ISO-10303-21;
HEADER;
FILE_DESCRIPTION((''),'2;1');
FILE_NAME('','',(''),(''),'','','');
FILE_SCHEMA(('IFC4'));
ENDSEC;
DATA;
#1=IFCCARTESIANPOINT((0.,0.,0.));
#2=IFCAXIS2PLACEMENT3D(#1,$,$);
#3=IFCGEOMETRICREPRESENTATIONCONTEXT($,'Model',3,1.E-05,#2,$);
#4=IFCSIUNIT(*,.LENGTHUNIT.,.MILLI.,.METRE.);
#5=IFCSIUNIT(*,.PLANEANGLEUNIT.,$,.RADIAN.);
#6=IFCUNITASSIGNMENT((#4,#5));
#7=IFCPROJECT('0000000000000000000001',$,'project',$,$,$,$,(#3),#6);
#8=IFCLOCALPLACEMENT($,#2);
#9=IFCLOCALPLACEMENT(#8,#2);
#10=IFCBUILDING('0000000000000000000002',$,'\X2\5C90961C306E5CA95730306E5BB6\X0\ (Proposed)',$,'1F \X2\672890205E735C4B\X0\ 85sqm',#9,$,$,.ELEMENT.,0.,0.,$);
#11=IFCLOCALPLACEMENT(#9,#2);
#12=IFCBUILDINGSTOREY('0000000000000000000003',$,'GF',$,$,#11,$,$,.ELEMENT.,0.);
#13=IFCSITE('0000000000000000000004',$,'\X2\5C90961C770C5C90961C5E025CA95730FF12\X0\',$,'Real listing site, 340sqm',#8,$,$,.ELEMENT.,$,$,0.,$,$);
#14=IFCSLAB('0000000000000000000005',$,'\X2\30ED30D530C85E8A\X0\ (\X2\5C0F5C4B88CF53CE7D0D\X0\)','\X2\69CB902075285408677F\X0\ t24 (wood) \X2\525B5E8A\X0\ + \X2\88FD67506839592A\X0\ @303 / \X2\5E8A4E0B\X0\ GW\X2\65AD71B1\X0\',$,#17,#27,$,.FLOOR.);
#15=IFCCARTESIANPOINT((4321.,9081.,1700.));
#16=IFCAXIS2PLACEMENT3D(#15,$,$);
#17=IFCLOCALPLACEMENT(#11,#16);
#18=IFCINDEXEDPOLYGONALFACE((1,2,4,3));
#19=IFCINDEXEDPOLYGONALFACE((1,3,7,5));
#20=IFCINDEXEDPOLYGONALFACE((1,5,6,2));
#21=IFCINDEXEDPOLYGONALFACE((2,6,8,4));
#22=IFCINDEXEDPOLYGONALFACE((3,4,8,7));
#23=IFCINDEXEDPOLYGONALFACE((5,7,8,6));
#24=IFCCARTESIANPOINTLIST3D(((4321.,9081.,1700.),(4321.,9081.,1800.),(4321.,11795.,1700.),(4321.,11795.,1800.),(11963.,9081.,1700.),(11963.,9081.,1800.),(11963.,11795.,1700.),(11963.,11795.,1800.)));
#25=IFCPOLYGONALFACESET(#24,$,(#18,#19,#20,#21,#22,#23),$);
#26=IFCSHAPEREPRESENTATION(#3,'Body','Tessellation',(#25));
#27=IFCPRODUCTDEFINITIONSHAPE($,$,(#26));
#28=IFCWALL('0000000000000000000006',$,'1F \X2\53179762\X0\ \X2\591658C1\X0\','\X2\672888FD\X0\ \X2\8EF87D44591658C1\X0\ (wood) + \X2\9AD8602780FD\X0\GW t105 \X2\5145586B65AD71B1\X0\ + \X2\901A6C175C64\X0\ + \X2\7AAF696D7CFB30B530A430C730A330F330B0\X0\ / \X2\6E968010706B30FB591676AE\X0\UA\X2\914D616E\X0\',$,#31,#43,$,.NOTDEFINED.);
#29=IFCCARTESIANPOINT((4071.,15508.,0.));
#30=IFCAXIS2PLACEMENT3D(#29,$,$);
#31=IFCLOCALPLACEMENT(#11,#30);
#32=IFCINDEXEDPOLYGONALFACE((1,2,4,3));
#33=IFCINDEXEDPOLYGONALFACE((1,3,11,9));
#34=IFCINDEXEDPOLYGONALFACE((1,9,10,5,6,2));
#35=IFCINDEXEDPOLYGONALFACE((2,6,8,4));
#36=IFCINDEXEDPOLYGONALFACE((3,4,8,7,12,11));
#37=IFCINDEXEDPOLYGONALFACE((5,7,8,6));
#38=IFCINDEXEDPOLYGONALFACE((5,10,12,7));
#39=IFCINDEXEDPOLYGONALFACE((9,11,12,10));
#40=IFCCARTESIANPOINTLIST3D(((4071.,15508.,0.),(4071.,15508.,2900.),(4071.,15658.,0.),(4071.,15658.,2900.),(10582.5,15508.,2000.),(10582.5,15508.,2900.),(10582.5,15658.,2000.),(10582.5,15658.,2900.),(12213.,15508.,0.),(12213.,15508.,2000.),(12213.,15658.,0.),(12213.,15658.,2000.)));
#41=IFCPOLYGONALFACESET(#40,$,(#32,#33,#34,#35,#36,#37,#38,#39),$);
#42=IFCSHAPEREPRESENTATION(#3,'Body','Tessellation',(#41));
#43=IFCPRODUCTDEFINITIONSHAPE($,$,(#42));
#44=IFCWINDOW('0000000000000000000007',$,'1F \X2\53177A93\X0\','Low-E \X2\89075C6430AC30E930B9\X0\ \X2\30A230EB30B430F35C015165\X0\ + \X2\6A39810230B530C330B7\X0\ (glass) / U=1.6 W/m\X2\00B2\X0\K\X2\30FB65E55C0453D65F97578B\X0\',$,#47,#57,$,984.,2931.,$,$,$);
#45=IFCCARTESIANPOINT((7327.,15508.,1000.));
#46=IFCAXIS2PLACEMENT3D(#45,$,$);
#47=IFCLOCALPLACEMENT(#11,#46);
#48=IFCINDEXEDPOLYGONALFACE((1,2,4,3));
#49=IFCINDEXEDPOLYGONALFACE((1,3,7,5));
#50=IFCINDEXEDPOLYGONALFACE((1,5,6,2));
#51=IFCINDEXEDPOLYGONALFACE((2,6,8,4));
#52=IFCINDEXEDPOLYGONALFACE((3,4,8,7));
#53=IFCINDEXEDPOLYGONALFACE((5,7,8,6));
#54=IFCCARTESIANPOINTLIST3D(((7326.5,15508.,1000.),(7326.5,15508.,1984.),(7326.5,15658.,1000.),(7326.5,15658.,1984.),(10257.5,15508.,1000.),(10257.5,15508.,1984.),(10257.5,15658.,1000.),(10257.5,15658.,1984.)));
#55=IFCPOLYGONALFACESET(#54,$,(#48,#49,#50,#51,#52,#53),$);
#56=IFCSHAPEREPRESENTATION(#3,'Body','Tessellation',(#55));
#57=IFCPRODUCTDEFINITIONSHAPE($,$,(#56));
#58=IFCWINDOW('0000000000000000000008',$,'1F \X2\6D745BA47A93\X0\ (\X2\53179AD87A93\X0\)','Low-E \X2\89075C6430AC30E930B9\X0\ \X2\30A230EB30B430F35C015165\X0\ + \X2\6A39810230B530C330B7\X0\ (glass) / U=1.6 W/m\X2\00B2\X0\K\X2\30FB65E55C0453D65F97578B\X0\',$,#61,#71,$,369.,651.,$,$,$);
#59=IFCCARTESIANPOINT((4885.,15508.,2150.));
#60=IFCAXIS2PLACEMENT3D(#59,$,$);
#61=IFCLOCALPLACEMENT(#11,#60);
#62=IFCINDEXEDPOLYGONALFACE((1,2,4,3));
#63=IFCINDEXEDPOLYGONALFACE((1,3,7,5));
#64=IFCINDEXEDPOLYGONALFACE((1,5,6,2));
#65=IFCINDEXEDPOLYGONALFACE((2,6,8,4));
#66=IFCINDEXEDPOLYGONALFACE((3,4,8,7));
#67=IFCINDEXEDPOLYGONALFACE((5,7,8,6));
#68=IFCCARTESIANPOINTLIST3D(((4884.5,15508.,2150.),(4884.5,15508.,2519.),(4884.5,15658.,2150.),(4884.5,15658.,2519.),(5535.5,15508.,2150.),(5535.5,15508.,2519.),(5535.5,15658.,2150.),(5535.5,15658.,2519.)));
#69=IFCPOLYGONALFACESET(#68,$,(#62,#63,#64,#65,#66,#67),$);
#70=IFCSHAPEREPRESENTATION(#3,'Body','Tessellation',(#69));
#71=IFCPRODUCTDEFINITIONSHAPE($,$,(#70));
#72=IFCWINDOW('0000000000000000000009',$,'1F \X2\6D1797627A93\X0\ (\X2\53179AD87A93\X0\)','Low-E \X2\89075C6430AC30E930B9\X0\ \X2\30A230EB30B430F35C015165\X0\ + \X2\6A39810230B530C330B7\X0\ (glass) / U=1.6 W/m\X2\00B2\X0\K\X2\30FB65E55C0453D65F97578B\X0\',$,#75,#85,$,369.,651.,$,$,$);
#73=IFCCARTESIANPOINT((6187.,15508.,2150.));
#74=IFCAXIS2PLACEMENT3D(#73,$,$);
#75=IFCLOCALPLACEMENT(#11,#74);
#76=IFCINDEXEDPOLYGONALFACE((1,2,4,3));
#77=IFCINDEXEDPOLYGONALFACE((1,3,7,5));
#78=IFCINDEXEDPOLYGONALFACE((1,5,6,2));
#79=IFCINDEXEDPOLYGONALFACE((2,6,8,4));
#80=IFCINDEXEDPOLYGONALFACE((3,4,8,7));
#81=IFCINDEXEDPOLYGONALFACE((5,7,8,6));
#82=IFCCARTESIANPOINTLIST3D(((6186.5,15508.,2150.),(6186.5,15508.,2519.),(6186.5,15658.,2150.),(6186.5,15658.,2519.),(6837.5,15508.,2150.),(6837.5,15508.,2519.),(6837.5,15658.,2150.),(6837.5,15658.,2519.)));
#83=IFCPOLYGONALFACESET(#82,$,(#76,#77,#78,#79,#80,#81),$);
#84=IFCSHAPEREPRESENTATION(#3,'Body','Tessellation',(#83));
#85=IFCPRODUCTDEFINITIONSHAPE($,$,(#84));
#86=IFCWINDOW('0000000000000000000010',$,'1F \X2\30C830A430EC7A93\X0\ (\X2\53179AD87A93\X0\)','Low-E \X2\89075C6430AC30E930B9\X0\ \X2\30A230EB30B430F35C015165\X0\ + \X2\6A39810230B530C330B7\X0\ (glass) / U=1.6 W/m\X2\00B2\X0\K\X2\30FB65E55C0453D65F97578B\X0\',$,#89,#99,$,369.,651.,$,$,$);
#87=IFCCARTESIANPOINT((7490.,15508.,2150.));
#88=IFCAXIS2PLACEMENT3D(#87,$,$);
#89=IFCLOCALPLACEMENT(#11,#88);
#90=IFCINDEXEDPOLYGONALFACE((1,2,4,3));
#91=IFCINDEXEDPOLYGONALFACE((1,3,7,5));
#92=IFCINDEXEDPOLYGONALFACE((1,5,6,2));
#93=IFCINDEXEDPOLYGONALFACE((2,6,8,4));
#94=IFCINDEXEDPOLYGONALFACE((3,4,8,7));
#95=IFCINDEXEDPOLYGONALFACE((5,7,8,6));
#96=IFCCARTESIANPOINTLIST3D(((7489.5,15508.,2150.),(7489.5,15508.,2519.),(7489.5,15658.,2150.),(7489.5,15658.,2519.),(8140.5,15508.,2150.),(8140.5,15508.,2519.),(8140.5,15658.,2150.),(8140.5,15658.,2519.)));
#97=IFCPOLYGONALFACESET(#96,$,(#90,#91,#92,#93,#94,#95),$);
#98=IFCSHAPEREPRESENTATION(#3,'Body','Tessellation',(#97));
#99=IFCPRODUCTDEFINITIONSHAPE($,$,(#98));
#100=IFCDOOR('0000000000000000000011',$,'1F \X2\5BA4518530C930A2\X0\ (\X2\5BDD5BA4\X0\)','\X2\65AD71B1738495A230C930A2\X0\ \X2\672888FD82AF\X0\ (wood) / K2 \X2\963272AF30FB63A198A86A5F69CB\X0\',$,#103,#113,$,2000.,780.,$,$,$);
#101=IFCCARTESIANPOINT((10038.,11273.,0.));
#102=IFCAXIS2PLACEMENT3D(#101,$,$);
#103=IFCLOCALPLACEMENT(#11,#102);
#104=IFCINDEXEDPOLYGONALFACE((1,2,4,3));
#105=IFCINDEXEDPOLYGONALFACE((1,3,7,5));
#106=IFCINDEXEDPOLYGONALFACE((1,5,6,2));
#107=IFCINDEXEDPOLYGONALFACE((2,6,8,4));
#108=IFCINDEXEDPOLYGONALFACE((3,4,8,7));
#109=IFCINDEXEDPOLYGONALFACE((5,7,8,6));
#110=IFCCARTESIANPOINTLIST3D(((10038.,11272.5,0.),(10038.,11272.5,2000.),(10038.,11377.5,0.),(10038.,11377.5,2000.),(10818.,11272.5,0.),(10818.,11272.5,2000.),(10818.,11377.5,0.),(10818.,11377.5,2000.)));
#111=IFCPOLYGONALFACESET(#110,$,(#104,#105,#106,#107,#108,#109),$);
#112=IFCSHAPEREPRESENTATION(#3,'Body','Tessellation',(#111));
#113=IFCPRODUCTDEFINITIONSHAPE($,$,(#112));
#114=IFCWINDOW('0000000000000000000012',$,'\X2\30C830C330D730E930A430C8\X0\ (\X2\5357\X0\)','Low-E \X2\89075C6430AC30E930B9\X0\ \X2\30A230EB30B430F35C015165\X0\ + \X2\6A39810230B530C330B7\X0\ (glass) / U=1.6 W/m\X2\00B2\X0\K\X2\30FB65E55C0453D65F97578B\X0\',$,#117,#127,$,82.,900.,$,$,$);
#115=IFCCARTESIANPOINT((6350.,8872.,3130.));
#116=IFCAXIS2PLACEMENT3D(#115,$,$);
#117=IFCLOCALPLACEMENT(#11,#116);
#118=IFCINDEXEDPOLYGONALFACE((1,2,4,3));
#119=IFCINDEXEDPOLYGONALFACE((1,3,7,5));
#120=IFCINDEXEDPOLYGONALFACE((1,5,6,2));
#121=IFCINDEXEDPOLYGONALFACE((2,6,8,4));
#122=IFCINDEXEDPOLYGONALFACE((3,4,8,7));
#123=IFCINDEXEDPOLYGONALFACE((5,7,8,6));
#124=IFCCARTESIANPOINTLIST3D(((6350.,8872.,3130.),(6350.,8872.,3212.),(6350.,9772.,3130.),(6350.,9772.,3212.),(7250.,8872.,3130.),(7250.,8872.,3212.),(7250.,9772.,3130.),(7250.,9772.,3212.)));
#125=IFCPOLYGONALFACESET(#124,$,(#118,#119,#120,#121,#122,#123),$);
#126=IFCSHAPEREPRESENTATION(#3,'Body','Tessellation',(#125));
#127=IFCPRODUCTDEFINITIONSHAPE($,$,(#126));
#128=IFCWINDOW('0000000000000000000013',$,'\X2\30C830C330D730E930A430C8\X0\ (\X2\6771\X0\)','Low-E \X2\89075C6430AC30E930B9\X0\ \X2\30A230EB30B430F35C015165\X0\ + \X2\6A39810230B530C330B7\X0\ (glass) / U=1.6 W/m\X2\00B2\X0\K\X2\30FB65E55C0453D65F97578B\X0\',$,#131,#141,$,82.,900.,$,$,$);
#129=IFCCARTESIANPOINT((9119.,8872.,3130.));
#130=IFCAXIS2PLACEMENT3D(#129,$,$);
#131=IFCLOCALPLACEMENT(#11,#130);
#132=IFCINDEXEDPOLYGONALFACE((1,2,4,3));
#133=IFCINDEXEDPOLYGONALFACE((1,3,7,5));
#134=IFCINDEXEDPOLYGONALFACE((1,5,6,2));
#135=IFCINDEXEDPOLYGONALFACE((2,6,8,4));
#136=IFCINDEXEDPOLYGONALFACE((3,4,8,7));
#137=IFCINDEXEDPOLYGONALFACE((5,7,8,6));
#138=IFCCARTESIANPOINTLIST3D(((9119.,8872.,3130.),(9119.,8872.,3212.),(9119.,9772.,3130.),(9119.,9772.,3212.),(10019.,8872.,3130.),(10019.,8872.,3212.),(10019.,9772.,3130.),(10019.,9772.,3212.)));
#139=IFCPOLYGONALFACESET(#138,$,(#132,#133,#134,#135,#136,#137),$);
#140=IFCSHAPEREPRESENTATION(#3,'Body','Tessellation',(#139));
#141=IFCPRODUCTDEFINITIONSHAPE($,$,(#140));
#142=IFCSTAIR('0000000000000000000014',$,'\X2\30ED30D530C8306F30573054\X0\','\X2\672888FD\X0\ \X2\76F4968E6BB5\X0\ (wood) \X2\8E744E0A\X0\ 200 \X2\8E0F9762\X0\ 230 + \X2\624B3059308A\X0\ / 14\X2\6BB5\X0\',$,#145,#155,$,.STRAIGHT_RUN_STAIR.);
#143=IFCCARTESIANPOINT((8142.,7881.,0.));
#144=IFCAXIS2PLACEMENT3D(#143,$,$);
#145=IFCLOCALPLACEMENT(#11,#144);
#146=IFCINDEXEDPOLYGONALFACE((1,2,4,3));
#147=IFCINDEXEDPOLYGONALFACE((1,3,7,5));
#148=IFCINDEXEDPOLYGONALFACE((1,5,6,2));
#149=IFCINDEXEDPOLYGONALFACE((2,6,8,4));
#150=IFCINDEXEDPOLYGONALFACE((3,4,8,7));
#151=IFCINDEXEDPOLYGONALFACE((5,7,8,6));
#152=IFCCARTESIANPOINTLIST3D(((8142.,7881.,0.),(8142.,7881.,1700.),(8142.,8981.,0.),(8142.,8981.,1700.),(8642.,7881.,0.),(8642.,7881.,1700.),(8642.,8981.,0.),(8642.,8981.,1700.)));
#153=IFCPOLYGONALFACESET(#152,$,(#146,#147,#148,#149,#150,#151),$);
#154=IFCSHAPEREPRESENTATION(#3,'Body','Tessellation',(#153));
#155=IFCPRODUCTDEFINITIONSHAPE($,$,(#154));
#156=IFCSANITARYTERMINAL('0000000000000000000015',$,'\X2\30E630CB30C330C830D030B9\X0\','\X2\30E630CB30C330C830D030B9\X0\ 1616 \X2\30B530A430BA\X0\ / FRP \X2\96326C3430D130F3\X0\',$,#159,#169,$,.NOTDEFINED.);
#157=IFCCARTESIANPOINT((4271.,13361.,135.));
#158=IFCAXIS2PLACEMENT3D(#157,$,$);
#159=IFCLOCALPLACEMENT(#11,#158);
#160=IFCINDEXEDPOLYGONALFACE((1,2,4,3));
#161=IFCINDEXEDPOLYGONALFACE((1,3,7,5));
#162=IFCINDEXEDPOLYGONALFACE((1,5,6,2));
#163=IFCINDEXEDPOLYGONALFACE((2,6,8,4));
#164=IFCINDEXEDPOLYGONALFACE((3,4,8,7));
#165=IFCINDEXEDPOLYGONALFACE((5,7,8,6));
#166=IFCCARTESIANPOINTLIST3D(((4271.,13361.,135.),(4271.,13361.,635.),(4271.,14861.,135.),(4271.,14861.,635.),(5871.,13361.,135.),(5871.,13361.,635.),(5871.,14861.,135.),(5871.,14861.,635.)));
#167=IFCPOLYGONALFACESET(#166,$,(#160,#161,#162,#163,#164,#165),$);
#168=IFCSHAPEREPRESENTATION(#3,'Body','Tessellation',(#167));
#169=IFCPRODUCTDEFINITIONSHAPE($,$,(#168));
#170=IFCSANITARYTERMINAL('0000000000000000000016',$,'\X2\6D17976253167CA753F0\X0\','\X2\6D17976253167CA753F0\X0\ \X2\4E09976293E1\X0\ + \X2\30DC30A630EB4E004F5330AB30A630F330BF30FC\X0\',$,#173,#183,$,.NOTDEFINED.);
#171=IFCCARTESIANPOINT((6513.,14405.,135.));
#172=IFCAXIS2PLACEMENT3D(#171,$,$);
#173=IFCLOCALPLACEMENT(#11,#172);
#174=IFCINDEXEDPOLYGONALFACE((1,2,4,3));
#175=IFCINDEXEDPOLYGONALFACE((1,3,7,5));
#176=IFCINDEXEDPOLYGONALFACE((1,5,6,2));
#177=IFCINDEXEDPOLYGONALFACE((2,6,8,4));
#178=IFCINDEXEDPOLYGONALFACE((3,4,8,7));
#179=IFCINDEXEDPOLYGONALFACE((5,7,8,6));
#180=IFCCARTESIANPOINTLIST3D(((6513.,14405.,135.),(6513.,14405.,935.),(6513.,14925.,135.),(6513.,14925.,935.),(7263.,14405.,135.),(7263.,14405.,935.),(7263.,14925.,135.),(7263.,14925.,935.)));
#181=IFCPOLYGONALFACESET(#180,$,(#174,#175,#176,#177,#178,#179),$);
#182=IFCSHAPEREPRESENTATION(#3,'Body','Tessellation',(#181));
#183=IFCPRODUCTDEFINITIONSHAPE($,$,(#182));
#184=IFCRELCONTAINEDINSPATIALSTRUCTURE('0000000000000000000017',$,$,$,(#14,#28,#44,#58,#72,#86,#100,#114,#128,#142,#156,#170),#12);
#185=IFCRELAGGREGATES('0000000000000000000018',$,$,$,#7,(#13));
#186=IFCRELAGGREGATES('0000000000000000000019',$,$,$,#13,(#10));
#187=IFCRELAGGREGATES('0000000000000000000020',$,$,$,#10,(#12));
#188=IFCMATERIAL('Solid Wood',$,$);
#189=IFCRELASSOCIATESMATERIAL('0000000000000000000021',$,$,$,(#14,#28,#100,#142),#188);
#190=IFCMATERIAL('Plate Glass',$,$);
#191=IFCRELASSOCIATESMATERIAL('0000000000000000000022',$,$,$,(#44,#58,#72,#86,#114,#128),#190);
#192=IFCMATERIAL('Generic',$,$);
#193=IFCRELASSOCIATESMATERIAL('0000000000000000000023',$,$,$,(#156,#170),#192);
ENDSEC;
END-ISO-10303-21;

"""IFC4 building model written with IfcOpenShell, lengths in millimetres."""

from ifc_helpers import new_model, si_unit, frame, frame_2d, origin, place, context, project, spatial, rectangle, extrude, material, element, fill, save


model = new_model("IFC4")

# Units and contexts
model_context = context("Model", 3, precision=1e-05, world=origin())
ifc_project = project(units=[si_unit("LENGTHUNIT", "METRE", prefix="MILLI"), si_unit("PLANEANGLEUNIT", "RADIAN")], contexts=[model_context])

# Site, building, storey
site_placement = place(None, origin())
site = spatial("IfcSite", under=ifc_project, at=site_placement, Name="岐阜県岐阜市岩地２", ObjectType="Real listing site, 340sqm", CompositionType="ELEMENT", RefElevation=0.0)
building_placement = place(site_placement, origin())
building = spatial("IfcBuilding", under=site, at=building_placement, Name="岐阜の岩地の家 (Proposed)", ObjectType="1F 木造平屋 85sqm", CompositionType="ELEMENT", ElevationOfRefHeight=0.0, ElevationOfTerrain=0.0)
storey_placement = place(building_placement, origin())
storey = spatial("IfcBuildingStorey", under=building, at=storey_placement, Name="GF", CompositionType="ELEMENT", Elevation=0.0)

# Slab
ifc_material_1 = material(Name="Solid Wood")
slab_placement = place(storey_placement, frame((4321.0, 9081.0, 1700.0)))
element("IfcSlab", 1, at=slab_placement, inside=storey, material=ifc_material_1, Name="ロフト床 (小屋裏収納)", Description="構造用合板 t24 (wood) 剛床 + 製材根太 @303 / 床下 GW断熱", PredefinedType="FLOOR", context=model_context, shape_type="SweptSolid", body=[
    extrude(rectangle(XDim=7642.0, YDim=2714.0, at=frame_2d((3821.0, 1357.0))), frame((4321.0, 9081.0, 1700.0)), (0.0, 0.0, 1.0), 100.0),
])

# Wall, openings, windows
wall_1_placement = place(storey_placement, frame((4071.0, 15508.0, 0.0)))
wall_1 = element("IfcWall", 2, at=wall_1_placement, inside=storey, material=ifc_material_1, Name="1F 北面 外壁", Description="木製 軸組外壁 (wood) + 高性能GW t105 充填断熱 + 通気層 + 窯業系サイディング / 準耐火・外皮UA配慮", PredefinedType="NOTDEFINED", context=model_context, shape_type="SweptSolid", body=[
    extrude(rectangle(XDim=8142.0, YDim=150.0, at=frame_2d((4071.0, 75.0))), frame((4071.0, 15508.0, 0.0)), (0.0, 0.0, 1.0), 2900.0),
])
opening_1_placement = place(storey_placement, frame((7327.0, 15508.0, 1000.0)))
opening_1 = element("IfcOpeningElement", 3, at=opening_1_placement, cuts=wall_1, PredefinedType="NOTDEFINED", context=model_context, shape_type="SweptSolid", body=[
    extrude(rectangle(XDim=2931.0, YDim=150.0, at=frame_2d((1465.0, 75.0))), frame((7327.0, 15508.0, 1000.0)), (0.0, 0.0, 1.0), 984.0),
])
opening_2_placement = place(storey_placement, frame((4885.0, 15508.0, 2150.0)))
opening_2 = element("IfcOpeningElement", 4, at=opening_2_placement, cuts=wall_1, PredefinedType="NOTDEFINED", context=model_context, shape_type="SweptSolid", body=[
    extrude(rectangle(XDim=651.0, YDim=150.0, at=frame_2d((325.0, 75.0))), frame((4885.0, 15508.0, 2150.0)), (0.0, 0.0, 1.0), 369.0),
])
opening_3_placement = place(storey_placement, frame((6187.0, 15508.0, 2150.0)))
opening_3 = element("IfcOpeningElement", 5, at=opening_3_placement, cuts=wall_1, PredefinedType="NOTDEFINED", context=model_context, shape_type="SweptSolid", body=[
    extrude(rectangle(XDim=651.0, YDim=150.0, at=frame_2d((325.0, 75.0))), frame((6187.0, 15508.0, 2150.0)), (0.0, 0.0, 1.0), 369.0),
])
opening_4_placement = place(storey_placement, frame((7490.0, 15508.0, 2150.0)))
opening_4 = element("IfcOpeningElement", 6, at=opening_4_placement, cuts=wall_1, PredefinedType="NOTDEFINED", context=model_context, shape_type="SweptSolid", body=[
    extrude(rectangle(XDim=651.0, YDim=150.0, at=frame_2d((325.0, 75.0))), frame((7490.0, 15508.0, 2150.0)), (0.0, 0.0, 1.0), 369.0),
])
ifc_material_2 = material(Name="Plate Glass")
window_1_placement = place(storey_placement, frame((7327.0, 15508.0, 1000.0)))
window_1 = element("IfcWindow", 7, at=window_1_placement, inside=storey, material=ifc_material_2, Name="1F 北窓", Description="Low-E 複層ガラス アルゴン封入 + 樹脂サッシ (glass) / U=1.6 W/m²K・日射取得型", OverallHeight=984.0, OverallWidth=2931.0, context=model_context, shape_type="SweptSolid", body=[
    extrude(rectangle(XDim=2931.0, YDim=150.0, at=frame_2d((1465.0, 75.0))), frame((7327.0, 15508.0, 1000.0)), (0.0, 0.0, 1.0), 984.0),
])
fill(opening_1, window_1)
window_2_placement = place(storey_placement, frame((4885.0, 15508.0, 2150.0)))
window_2 = element("IfcWindow", 8, at=window_2_placement, inside=storey, material=ifc_material_2, Name="1F 浴室窓 (北高窓)", Description="Low-E 複層ガラス アルゴン封入 + 樹脂サッシ (glass) / U=1.6 W/m²K・日射取得型", OverallHeight=369.0, OverallWidth=651.0, context=model_context, shape_type="SweptSolid", body=[
    extrude(rectangle(XDim=651.0, YDim=150.0, at=frame_2d((325.0, 75.0))), frame((4885.0, 15508.0, 2150.0)), (0.0, 0.0, 1.0), 369.0),
])
fill(opening_2, window_2)
window_3_placement = place(storey_placement, frame((6187.0, 15508.0, 2150.0)))
window_3 = element("IfcWindow", 9, at=window_3_placement, inside=storey, material=ifc_material_2, Name="1F 洗面窓 (北高窓)", Description="Low-E 複層ガラス アルゴン封入 + 樹脂サッシ (glass) / U=1.6 W/m²K・日射取得型", OverallHeight=369.0, OverallWidth=651.0, context=model_context, shape_type="SweptSolid", body=[
    extrude(rectangle(XDim=651.0, YDim=150.0, at=frame_2d((325.0, 75.0))), frame((6187.0, 15508.0, 2150.0)), (0.0, 0.0, 1.0), 369.0),
])
fill(opening_3, window_3)
window_4_placement = place(storey_placement, frame((7490.0, 15508.0, 2150.0)))
window_4 = element("IfcWindow", 10, at=window_4_placement, inside=storey, material=ifc_material_2, Name="1F トイレ窓 (北高窓)", Description="Low-E 複層ガラス アルゴン封入 + 樹脂サッシ (glass) / U=1.6 W/m²K・日射取得型", OverallHeight=369.0, OverallWidth=651.0, context=model_context, shape_type="SweptSolid", body=[
    extrude(rectangle(XDim=651.0, YDim=150.0, at=frame_2d((325.0, 75.0))), frame((7490.0, 15508.0, 2150.0)), (0.0, 0.0, 1.0), 369.0),
])
fill(opening_4, window_4)

# Door
door_1_placement = place(storey_placement, frame((10038.0, 11273.0, 0.0)))
element("IfcDoor", 11, at=door_1_placement, inside=storey, material=ifc_material_1, Name="1F 室内ドア (寝室)", Description="断熱玄関ドア 木製芯 (wood) / K2 防犯・採風機構", OverallHeight=2000.0, OverallWidth=780.0, context=model_context, shape_type="SweptSolid", body=[
    extrude(rectangle(XDim=780.0, YDim=105.0, at=frame_2d((390.0, 52.0))), frame((10038.0, 11273.0, 0.0)), (0.0, 0.0, 1.0), 2000.0),
])

# Windows
window_5_placement = place(storey_placement, frame((6350.0, 8872.0, 3130.0)))
element("IfcWindow", 12, at=window_5_placement, inside=storey, material=ifc_material_2, Name="トップライト (南)", Description="Low-E 複層ガラス アルゴン封入 + 樹脂サッシ (glass) / U=1.6 W/m²K・日射取得型", OverallHeight=82.0, OverallWidth=900.0, context=model_context, shape_type="SweptSolid", body=[
    extrude(rectangle(XDim=900.0, YDim=900.0, at=frame_2d((450.0, 450.0))), frame((6350.0, 8872.0, 3130.0)), (0.0, 0.0, 1.0), 82.0),
])
window_6_placement = place(storey_placement, frame((9119.0, 8872.0, 3130.0)))
element("IfcWindow", 13, at=window_6_placement, inside=storey, material=ifc_material_2, Name="トップライト (東)", Description="Low-E 複層ガラス アルゴン封入 + 樹脂サッシ (glass) / U=1.6 W/m²K・日射取得型", OverallHeight=82.0, OverallWidth=900.0, context=model_context, shape_type="SweptSolid", body=[
    extrude(rectangle(XDim=900.0, YDim=900.0, at=frame_2d((450.0, 450.0))), frame((9119.0, 8872.0, 3130.0)), (0.0, 0.0, 1.0), 82.0),
])

# Stair
stair_placement = place(storey_placement, frame((8142.0, 7881.0, 0.0)))
element("IfcStair", 14, at=stair_placement, inside=storey, material=ifc_material_1, Name="ロフトはしご", Description="木製 直階段 (wood) 蹴上 200 踏面 230 + 手すり / 14段", PredefinedType="STRAIGHT_RUN_STAIR", context=model_context, shape_type="SweptSolid", body=[
    extrude(rectangle(XDim=500.0, YDim=1100.0, at=frame_2d((250.0, 550.0))), frame((8142.0, 7881.0, 0.0)), (0.0, 0.0, 1.0), 1700.0),
])

# Sanitary terminals
ifc_material_3 = material(Name="Generic")
sanitary_terminal_1_placement = place(storey_placement, frame((4271.0, 13361.0, 135.0)))
element("IfcSanitaryTerminal", 15, at=sanitary_terminal_1_placement, inside=storey, material=ifc_material_3, Name="ユニットバス", Description="ユニットバス 1616 サイズ / FRP 防水パン", PredefinedType="NOTDEFINED", context=model_context, shape_type="SweptSolid", body=[
    extrude(rectangle(XDim=1600.0, YDim=1500.0, at=frame_2d((800.0, 750.0))), frame((4271.0, 13361.0, 135.0)), (0.0, 0.0, 1.0), 500.0),
])
sanitary_terminal_2_placement = place(storey_placement, frame((6513.0, 14405.0, 135.0)))
element("IfcSanitaryTerminal", 16, at=sanitary_terminal_2_placement, inside=storey, material=ifc_material_3, Name="洗面化粧台", Description="洗面化粧台 三面鏡 + ボウル一体カウンター", PredefinedType="NOTDEFINED", context=model_context, shape_type="SweptSolid", body=[
    extrude(rectangle(XDim=750.0, YDim=520.0, at=frame_2d((375.0, 260.0))), frame((6513.0, 14405.0, 135.0)), (0.0, 0.0, 1.0), 800.0),
])

save(model, "model.ifc")
